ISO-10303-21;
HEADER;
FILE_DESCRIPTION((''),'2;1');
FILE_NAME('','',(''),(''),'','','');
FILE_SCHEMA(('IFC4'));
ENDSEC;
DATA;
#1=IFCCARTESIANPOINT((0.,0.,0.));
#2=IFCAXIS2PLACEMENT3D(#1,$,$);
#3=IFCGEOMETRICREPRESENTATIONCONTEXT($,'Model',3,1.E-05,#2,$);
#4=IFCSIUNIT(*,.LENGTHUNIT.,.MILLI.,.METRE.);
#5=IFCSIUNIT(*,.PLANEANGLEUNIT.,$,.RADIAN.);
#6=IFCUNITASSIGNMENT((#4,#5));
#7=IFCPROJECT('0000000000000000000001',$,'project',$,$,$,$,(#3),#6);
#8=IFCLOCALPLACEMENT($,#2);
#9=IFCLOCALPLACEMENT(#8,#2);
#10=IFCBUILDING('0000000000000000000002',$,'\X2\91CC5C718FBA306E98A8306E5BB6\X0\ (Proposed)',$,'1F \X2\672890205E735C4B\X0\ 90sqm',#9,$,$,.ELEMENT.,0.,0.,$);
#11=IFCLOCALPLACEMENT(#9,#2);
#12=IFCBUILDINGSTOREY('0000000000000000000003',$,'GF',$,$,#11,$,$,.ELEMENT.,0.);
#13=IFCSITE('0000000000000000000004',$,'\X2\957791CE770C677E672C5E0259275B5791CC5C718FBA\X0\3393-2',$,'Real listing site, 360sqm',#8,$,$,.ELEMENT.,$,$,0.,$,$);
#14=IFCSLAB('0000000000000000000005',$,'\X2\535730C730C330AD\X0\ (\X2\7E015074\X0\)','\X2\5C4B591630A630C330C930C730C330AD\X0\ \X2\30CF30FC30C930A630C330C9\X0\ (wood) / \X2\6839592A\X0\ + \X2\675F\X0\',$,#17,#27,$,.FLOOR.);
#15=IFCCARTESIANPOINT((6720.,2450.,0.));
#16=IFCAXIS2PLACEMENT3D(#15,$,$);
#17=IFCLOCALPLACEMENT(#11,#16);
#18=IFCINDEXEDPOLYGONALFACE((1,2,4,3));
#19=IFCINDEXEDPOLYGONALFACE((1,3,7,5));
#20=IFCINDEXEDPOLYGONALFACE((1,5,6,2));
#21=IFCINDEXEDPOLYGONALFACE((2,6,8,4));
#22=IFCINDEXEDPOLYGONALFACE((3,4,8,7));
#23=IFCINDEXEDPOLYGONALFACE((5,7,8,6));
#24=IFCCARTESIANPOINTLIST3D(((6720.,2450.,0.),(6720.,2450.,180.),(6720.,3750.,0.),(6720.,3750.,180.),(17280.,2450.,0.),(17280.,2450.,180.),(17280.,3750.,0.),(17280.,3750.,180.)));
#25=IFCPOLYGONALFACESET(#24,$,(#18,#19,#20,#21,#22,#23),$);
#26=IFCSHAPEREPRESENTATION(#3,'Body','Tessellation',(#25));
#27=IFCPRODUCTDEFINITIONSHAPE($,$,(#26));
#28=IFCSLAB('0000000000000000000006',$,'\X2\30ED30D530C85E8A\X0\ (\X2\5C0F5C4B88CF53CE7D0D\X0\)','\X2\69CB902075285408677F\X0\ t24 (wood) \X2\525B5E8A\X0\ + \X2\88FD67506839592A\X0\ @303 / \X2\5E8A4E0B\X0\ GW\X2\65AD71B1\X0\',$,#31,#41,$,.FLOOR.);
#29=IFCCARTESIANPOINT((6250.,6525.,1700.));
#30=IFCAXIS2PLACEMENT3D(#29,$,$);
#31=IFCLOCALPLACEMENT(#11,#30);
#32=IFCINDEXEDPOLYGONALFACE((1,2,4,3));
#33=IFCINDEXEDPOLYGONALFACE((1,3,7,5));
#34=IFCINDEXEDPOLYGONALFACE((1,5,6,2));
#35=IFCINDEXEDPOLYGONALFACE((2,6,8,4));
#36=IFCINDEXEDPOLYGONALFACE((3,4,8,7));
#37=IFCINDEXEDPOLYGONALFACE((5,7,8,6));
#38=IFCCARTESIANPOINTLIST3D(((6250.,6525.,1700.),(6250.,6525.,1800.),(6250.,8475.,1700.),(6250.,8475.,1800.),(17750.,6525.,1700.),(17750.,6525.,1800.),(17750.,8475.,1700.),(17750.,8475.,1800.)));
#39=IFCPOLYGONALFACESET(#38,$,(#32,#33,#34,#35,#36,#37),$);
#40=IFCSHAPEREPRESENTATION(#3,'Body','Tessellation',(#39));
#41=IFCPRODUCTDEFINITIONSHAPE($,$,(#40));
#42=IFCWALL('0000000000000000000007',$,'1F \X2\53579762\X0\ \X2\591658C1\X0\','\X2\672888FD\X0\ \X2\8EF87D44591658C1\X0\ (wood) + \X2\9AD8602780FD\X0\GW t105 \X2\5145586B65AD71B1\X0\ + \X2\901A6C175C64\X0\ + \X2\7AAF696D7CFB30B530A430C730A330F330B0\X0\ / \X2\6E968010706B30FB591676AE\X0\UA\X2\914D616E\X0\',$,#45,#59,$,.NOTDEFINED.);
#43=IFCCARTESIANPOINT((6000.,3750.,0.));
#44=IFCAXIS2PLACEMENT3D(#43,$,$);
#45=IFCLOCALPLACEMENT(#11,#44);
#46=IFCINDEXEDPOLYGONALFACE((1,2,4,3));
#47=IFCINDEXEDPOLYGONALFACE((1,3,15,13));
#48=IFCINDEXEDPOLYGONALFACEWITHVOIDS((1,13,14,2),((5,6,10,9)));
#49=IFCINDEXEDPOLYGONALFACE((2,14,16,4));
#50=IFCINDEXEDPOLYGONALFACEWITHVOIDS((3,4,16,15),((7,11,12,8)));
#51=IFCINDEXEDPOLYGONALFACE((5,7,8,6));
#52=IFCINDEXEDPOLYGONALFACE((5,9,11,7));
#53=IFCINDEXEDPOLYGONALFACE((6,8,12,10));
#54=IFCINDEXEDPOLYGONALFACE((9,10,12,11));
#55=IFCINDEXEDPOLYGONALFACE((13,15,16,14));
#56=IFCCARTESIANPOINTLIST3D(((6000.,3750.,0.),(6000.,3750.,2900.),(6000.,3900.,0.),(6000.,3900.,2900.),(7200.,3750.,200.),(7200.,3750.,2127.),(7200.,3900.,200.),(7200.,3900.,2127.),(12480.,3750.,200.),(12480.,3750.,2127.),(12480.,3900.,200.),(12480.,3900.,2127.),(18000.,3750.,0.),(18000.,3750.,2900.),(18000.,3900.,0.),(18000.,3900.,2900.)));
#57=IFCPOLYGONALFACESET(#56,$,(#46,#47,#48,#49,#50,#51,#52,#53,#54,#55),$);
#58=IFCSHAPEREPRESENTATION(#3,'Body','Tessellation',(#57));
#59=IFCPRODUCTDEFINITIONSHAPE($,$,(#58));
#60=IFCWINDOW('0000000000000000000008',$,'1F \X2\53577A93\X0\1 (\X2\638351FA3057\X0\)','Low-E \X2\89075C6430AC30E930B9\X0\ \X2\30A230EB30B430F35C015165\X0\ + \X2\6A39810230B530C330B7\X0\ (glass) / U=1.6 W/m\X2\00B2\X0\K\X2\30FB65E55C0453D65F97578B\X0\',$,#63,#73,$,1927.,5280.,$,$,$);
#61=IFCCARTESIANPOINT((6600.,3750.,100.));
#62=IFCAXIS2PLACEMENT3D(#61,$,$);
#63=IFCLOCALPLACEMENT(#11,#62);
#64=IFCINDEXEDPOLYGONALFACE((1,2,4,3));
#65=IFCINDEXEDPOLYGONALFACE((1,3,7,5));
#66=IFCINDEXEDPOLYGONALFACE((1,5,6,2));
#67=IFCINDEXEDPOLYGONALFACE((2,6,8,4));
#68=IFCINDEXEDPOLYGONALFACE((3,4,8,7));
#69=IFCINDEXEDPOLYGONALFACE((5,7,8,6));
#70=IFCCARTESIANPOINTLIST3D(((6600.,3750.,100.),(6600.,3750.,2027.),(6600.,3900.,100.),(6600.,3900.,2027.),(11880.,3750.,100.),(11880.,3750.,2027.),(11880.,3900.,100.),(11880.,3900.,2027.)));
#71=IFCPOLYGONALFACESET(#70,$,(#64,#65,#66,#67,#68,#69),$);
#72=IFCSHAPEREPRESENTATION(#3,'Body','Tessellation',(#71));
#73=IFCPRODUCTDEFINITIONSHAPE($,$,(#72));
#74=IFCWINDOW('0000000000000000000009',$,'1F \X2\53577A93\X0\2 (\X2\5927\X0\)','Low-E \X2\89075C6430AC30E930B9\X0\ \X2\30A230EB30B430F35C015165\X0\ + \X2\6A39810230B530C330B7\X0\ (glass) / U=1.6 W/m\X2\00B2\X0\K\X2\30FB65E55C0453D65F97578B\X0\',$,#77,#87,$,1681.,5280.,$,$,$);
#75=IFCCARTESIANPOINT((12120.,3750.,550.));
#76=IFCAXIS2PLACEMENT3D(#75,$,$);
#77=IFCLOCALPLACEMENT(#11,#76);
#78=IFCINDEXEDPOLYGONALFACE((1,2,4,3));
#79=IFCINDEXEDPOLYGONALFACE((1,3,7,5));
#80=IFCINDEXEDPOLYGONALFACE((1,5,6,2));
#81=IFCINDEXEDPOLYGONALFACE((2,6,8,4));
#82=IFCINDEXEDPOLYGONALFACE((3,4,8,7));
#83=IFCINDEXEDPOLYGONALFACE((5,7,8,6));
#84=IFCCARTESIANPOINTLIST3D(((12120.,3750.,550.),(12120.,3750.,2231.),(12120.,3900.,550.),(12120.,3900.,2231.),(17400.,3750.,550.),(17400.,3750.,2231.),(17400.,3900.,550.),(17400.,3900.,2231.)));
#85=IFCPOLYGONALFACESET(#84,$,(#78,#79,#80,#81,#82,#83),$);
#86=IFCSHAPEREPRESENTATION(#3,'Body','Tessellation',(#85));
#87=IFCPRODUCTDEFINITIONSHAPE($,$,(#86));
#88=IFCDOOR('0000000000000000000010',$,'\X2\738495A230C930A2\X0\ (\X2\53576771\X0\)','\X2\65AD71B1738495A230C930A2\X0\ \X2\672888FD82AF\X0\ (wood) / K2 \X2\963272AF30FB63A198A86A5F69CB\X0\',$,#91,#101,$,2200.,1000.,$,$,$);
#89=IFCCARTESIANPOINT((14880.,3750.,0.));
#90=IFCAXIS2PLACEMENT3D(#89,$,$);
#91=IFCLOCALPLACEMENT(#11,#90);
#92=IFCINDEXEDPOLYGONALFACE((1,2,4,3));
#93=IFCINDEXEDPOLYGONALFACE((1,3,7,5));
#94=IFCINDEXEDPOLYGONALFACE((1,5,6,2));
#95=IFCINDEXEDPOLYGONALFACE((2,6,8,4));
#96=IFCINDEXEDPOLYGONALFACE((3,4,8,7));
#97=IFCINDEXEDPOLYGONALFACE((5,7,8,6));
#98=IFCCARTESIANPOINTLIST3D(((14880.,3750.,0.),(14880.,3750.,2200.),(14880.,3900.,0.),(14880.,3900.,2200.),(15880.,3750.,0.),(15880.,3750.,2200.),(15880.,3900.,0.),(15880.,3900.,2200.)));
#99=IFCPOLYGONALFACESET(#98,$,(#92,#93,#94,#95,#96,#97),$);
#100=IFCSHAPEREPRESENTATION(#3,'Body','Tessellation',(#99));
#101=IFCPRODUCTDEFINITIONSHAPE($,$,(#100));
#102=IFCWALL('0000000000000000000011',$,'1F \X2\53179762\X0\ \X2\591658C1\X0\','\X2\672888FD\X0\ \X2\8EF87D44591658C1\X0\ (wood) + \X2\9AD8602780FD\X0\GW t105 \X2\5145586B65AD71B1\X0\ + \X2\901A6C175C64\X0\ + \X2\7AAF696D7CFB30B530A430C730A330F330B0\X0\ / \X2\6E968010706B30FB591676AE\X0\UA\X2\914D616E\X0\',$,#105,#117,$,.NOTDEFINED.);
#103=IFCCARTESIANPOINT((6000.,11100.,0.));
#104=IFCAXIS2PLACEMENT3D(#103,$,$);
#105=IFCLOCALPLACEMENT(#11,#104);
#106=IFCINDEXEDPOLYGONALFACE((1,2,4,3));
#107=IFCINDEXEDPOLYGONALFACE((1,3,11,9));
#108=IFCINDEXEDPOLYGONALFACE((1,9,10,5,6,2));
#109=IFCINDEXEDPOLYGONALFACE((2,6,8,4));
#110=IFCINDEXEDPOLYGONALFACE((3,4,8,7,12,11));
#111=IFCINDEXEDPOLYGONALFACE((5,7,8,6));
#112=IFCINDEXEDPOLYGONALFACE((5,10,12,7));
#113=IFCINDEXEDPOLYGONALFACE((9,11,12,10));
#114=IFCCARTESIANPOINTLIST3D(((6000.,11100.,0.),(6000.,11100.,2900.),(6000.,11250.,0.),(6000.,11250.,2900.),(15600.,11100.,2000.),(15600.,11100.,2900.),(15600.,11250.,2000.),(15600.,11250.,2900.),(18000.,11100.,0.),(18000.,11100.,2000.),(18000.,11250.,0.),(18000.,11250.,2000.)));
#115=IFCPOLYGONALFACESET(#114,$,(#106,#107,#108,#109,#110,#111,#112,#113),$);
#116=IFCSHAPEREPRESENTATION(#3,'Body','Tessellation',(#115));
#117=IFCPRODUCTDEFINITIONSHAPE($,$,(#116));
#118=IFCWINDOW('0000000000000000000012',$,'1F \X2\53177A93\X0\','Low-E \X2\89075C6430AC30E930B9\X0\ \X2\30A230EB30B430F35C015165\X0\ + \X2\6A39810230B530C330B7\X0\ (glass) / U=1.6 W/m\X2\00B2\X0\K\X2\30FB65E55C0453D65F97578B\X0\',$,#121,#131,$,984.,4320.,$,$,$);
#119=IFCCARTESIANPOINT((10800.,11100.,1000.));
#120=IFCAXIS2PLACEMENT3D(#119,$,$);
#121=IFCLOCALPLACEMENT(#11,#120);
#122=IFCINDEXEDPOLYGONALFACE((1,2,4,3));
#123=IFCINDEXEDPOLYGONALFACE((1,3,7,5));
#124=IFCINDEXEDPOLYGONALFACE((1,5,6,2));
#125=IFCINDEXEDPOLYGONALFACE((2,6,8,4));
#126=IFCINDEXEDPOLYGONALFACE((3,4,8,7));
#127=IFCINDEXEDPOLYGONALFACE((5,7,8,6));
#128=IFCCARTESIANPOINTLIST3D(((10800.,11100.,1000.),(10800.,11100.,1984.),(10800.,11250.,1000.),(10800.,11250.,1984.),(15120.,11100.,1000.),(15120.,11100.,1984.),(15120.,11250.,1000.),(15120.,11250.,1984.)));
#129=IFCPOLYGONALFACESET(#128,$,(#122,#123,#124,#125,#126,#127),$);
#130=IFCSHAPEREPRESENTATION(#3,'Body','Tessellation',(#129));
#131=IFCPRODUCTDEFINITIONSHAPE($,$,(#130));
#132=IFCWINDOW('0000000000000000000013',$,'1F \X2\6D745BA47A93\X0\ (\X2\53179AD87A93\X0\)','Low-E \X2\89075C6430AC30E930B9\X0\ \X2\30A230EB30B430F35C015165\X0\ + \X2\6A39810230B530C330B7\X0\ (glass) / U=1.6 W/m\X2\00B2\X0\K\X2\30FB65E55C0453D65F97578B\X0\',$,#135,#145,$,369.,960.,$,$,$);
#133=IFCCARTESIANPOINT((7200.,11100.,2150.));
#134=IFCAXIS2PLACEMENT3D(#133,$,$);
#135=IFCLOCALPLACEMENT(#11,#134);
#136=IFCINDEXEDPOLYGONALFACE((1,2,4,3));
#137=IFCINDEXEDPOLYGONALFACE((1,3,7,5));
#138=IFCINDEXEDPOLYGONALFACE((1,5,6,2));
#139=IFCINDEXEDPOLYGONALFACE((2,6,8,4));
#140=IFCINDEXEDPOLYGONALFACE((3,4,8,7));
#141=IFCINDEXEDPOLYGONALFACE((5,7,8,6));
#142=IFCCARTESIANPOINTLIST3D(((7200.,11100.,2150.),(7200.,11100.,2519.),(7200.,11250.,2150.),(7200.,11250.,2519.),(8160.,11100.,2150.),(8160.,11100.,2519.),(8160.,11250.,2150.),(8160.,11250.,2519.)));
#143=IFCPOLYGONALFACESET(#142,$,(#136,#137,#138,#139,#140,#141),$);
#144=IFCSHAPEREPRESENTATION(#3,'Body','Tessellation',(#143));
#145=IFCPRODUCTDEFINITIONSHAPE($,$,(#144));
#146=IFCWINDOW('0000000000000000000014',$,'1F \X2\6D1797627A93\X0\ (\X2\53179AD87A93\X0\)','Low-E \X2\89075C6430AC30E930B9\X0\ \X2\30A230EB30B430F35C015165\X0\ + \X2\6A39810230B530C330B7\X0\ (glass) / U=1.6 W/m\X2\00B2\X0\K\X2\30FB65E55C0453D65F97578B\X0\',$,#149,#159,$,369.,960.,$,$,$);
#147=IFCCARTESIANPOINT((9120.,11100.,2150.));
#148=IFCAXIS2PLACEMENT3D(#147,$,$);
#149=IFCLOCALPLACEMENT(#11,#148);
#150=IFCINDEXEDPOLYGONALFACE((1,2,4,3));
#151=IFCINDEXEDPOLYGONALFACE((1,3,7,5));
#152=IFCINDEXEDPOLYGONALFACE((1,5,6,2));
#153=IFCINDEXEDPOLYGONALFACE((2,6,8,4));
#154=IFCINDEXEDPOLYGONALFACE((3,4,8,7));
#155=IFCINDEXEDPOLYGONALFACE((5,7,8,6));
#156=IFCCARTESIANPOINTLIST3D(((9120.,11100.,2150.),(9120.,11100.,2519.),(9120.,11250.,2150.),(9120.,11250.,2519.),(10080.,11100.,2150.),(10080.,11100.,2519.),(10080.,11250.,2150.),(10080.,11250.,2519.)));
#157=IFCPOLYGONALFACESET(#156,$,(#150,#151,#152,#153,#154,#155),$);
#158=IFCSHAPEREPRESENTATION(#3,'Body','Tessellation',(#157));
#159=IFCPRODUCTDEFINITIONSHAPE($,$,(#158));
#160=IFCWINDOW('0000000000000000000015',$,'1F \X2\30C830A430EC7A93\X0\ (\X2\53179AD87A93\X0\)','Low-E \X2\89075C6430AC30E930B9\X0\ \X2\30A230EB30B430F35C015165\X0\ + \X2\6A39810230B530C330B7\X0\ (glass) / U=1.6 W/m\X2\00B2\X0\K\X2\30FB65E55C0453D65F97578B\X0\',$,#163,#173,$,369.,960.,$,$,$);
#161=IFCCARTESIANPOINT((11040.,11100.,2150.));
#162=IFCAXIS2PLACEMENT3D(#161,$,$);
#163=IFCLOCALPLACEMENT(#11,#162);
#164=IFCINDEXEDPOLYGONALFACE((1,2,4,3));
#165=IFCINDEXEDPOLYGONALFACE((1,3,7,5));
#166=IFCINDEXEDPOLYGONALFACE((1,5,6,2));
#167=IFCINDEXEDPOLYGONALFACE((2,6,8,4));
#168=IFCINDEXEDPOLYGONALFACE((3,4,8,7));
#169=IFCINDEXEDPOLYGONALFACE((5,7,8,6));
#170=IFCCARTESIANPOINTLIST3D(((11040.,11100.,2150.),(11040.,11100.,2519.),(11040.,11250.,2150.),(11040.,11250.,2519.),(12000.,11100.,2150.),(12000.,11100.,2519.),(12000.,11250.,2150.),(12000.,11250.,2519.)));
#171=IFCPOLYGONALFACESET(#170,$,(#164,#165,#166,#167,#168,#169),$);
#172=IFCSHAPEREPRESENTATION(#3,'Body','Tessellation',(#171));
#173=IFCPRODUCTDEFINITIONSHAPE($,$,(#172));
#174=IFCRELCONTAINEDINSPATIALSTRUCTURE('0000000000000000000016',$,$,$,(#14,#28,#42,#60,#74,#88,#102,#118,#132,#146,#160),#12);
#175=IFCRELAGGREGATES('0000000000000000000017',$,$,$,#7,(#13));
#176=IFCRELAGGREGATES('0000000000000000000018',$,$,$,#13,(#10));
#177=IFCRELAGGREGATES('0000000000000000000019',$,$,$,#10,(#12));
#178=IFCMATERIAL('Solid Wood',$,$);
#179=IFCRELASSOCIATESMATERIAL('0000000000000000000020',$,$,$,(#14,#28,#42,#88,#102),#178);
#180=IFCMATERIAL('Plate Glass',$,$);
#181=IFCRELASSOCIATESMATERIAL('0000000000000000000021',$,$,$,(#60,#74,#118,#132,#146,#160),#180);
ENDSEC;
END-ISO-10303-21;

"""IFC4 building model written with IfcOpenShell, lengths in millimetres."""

from ifc_helpers import new_model, si_unit, frame, frame_2d, origin, place, context, project, spatial, rectangle, extrude, material, element, fill, save


model = new_model("IFC4")

# Units and contexts
model_context = context("Model", 3, precision=1e-05, world=origin())
ifc_project = project(units=[si_unit("LENGTHUNIT", "METRE", prefix="MILLI"), si_unit("PLANEANGLEUNIT", "RADIAN")], contexts=[model_context])

# Site, building, storey
site_placement = place(None, origin())
site = spatial("IfcSite", under=ifc_project, at=site_placement, Name="長野県松本市大字里山辺3393-2", ObjectType="Real listing site, 360sqm", CompositionType="ELEMENT", RefElevation=0.0)
building_placement = place(site_placement, origin())
building = spatial("IfcBuilding", under=site, at=building_placement, Name="里山辺の風の家 (Proposed)", ObjectType="1F 木造平屋 90sqm", CompositionType="ELEMENT", ElevationOfRefHeight=0.0, ElevationOfTerrain=0.0)
storey_placement = place(building_placement, origin())
storey = spatial("IfcBuildingStorey", under=building, at=storey_placement, Name="GF", CompositionType="ELEMENT", Elevation=0.0)

# Slabs
ifc_material_1 = material(Name="Solid Wood")
slab_1_placement = place(storey_placement, frame((6720.0, 2450.0, 0.0)))
element("IfcSlab", 1, at=slab_1_placement, inside=storey, material=ifc_material_1, Name="南デッキ (縁側)", Description="屋外ウッドデッキ ハードウッド (wood) / 根太 + 束", PredefinedType="FLOOR", context=model_context, shape_type="SweptSolid", body=[
    extrude(rectangle(XDim=10560.0, YDim=1300.0, at=frame_2d((5280.0, 650.0))), frame((6720.0, 2450.0, 0.0)), (0.0, 0.0, 1.0), 180.0),
])
slab_2_placement = place(storey_placement, frame((6250.0, 6525.0, 1700.0)))
element("IfcSlab", 2, at=slab_2_placement, inside=storey, material=ifc_material_1, Name="ロフト床 (小屋裏収納)", Description="構造用合板 t24 (wood) 剛床 + 製材根太 @303 / 床下 GW断熱", PredefinedType="FLOOR", context=model_context, shape_type="SweptSolid", body=[
    extrude(rectangle(XDim=11500.0, YDim=1950.0, at=frame_2d((5750.0, 975.0))), frame((6250.0, 6525.0, 1700.0)), (0.0, 0.0, 1.0), 100.0),
])

# Wall, openings, windows, door
wall_1_placement = place(storey_placement, frame((6000.0, 3750.0, 0.0)))
wall_1 = element("IfcWall", 3, at=wall_1_placement, inside=storey, material=ifc_material_1, Name="1F 南面 外壁", Description="木製 軸組外壁 (wood) + 高性能GW t105 充填断熱 + 通気層 + 窯業系サイディング / 準耐火・外皮UA配慮", PredefinedType="NOTDEFINED", context=model_context, shape_type="SweptSolid", body=[
    extrude(rectangle(XDim=12000.0, YDim=150.0, at=frame_2d((6000.0, 75.0))), frame((6000.0, 3750.0, 0.0)), (0.0, 0.0, 1.0), 2900.0),
])
opening_1_placement = place(storey_placement, frame((6600.0, 3750.0, 100.0)))
opening_1 = element("IfcOpeningElement", 4, at=opening_1_placement, cuts=wall_1, PredefinedType="NOTDEFINED", context=model_context, shape_type="SweptSolid", body=[
    extrude(rectangle(XDim=5280.0, YDim=150.0, at=frame_2d((2640.0, 75.0))), frame((6600.0, 3750.0, 100.0)), (0.0, 0.0, 1.0), 1927.0),
])
opening_2_placement = place(storey_placement, frame((12120.0, 3750.0, 550.0)))
opening_2 = element("IfcOpeningElement", 5, at=opening_2_placement, cuts=wall_1, PredefinedType="NOTDEFINED", context=model_context, shape_type="SweptSolid", body=[
    extrude(rectangle(XDim=5280.0, YDim=150.0, at=frame_2d((2640.0, 75.0))), frame((12120.0, 3750.0, 550.0)), (0.0, 0.0, 1.0), 1681.0),
])
opening_3_placement = place(storey_placement, frame((14880.0, 3750.0, 0.0)))
opening_3 = element("IfcOpeningElement", 6, at=opening_3_placement, cuts=wall_1, PredefinedType="NOTDEFINED", context=model_context, shape_type="SweptSolid", body=[
    extrude(rectangle(XDim=1000.0, YDim=150.0, at=frame_2d((500.0, 75.0))), frame((14880.0, 3750.0, 0.0)), (0.0, 0.0, 1.0), 2200.0),
])
ifc_material_2 = material(Name="Plate Glass")
window_1_placement = place(storey_placement, frame((6600.0, 3750.0, 100.0)))
window_1 = element("IfcWindow", 7, at=window_1_placement, inside=storey, material=ifc_material_2, Name="1F 南窓1 (掃出し)", Description="Low-E 複層ガラス アルゴン封入 + 樹脂サッシ (glass) / U=1.6 W/m²K・日射取得型", OverallHeight=1927.0, OverallWidth=5280.0, context=model_context, shape_type="SweptSolid", body=[
    extrude(rectangle(XDim=5280.0, YDim=150.0, at=frame_2d((2640.0, 75.0))), frame((6600.0, 3750.0, 100.0)), (0.0, 0.0, 1.0), 1927.0),
])
fill(opening_1, window_1)
window_2_placement = place(storey_placement, frame((12120.0, 3750.0, 550.0)))
window_2 = element("IfcWindow", 8, at=window_2_placement, inside=storey, material=ifc_material_2, Name="1F 南窓2 (大)", Description="Low-E 複層ガラス アルゴン封入 + 樹脂サッシ (glass) / U=1.6 W/m²K・日射取得型", OverallHeight=1681.0, OverallWidth=5280.0, context=model_context, shape_type="SweptSolid", body=[
    extrude(rectangle(XDim=5280.0, YDim=150.0, at=frame_2d((2640.0, 75.0))), frame((12120.0, 3750.0, 550.0)), (0.0, 0.0, 1.0), 1681.0),
])
fill(opening_2, window_2)
door_1_placement = place(storey_placement, frame((14880.0, 3750.0, 0.0)))
door_1 = element("IfcDoor", 9, at=door_1_placement, inside=storey, material=ifc_material_1, Name="玄関ドア (南東)", Description="断熱玄関ドア 木製芯 (wood) / K2 防犯・採風機構", OverallHeight=2200.0, OverallWidth=1000.0, context=model_context, shape_type="SweptSolid", body=[
    extrude(rectangle(XDim=1000.0, YDim=150.0, at=frame_2d((500.0, 75.0))), frame((14880.0, 3750.0, 0.0)), (0.0, 0.0, 1.0), 2200.0),
])
fill(opening_3, door_1)

# Wall, openings, windows
wall_2_placement = place(storey_placement, frame((6000.0, 11100.0, 0.0)))
wall_2 = element("IfcWall", 10, at=wall_2_placement, inside=storey, material=ifc_material_1, Name="1F 北面 外壁", Description="木製 軸組外壁 (wood) + 高性能GW t105 充填断熱 + 通気層 + 窯業系サイディング / 準耐火・外皮UA配慮", PredefinedType="NOTDEFINED", context=model_context, shape_type="SweptSolid", body=[
    extrude(rectangle(XDim=12000.0, YDim=150.0, at=frame_2d((6000.0, 75.0))), frame((6000.0, 11100.0, 0.0)), (0.0, 0.0, 1.0), 2900.0),
])
opening_4_placement = place(storey_placement, frame((10800.0, 11100.0, 1000.0)))
opening_4 = element("IfcOpeningElement", 11, at=opening_4_placement, cuts=wall_2, PredefinedType="NOTDEFINED", context=model_context, shape_type="SweptSolid", body=[
    extrude(rectangle(XDim=4320.0, YDim=150.0, at=frame_2d((2160.0, 75.0))), frame((10800.0, 11100.0, 1000.0)), (0.0, 0.0, 1.0), 984.0),
])
opening_5_placement = place(storey_placement, frame((7200.0, 11100.0, 2150.0)))
opening_5 = element("IfcOpeningElement", 12, at=opening_5_placement, cuts=wall_2, PredefinedType="NOTDEFINED", context=model_context, shape_type="SweptSolid", body=[
    extrude(rectangle(XDim=960.0, YDim=150.0, at=frame_2d((480.0, 75.0))), frame((7200.0, 11100.0, 2150.0)), (0.0, 0.0, 1.0), 369.0),
])
opening_6_placement = place(storey_placement, frame((9120.0, 11100.0, 2150.0)))
opening_6 = element("IfcOpeningElement", 13, at=opening_6_placement, cuts=wall_2, PredefinedType="NOTDEFINED", context=model_context, shape_type="SweptSolid", body=[
    extrude(rectangle(XDim=960.0, YDim=150.0, at=frame_2d((480.0, 75.0))), frame((9120.0, 11100.0, 2150.0)), (0.0, 0.0, 1.0), 369.0),
])
opening_7_placement = place(storey_placement, frame((11040.0, 11100.0, 2150.0)))
opening_7 = element("IfcOpeningElement", 14, at=opening_7_placement, cuts=wall_2, PredefinedType="NOTDEFINED", context=model_context, shape_type="SweptSolid", body=[
    extrude(rectangle(XDim=960.0, YDim=150.0, at=frame_2d((480.0, 75.0))), frame((11040.0, 11100.0, 2150.0)), (0.0, 0.0, 1.0), 369.0),
])
window_3_placement = place(storey_placement, frame((10800.0, 11100.0, 1000.0)))
window_3 = element("IfcWindow", 15, at=window_3_placement, inside=storey, material=ifc_material_2, Name="1F 北窓", Description="Low-E 複層ガラス アルゴン封入 + 樹脂サッシ (glass) / U=1.6 W/m²K・日射取得型", OverallHeight=984.0, OverallWidth=4320.0, context=model_context, shape_type="SweptSolid", body=[
    extrude(rectangle(XDim=4320.0, YDim=150.0, at=frame_2d((2160.0, 75.0))), frame((10800.0, 11100.0, 1000.0)), (0.0, 0.0, 1.0), 984.0),
])
fill(opening_4, window_3)
window_4_placement = place(storey_placement, frame((7200.0, 11100.0, 2150.0)))
window_4 = element("IfcWindow", 16, at=window_4_placement, inside=storey, material=ifc_material_2, Name="1F 浴室窓 (北高窓)", Description="Low-E 複層ガラス アルゴン封入 + 樹脂サッシ (glass) / U=1.6 W/m²K・日射取得型", OverallHeight=369.0, OverallWidth=960.0, context=model_context, shape_type="SweptSolid", body=[
    extrude(rectangle(XDim=960.0, YDim=150.0, at=frame_2d((480.0, 75.0))), frame((7200.0, 11100.0, 2150.0)), (0.0, 0.0, 1.0), 369.0),
])
fill(opening_5, window_4)
window_5_placement = place(storey_placement, frame((9120.0, 11100.0, 2150.0)))
window_5 = element("IfcWindow", 17, at=window_5_placement, inside=storey, material=ifc_material_2, Name="1F 洗面窓 (北高窓)", Description="Low-E 複層ガラス アルゴン封入 + 樹脂サッシ (glass) / U=1.6 W/m²K・日射取得型", OverallHeight=369.0, OverallWidth=960.0, context=model_context, shape_type="SweptSolid", body=[
    extrude(rectangle(XDim=960.0, YDim=150.0, at=frame_2d((480.0, 75.0))), frame((9120.0, 11100.0, 2150.0)), (0.0, 0.0, 1.0), 369.0),
])
fill(opening_6, window_5)
window_6_placement = place(storey_placement, frame((11040.0, 11100.0, 2150.0)))
window_6 = element("IfcWindow", 18, at=window_6_placement, inside=storey, material=ifc_material_2, Name="1F トイレ窓 (北高窓)", Description="Low-E 複層ガラス アルゴン封入 + 樹脂サッシ (glass) / U=1.6 W/m²K・日射取得型", OverallHeight=369.0, OverallWidth=960.0, context=model_context, shape_type="SweptSolid", body=[
    extrude(rectangle(XDim=960.0, YDim=150.0, at=frame_2d((480.0, 75.0))), frame((11040.0, 11100.0, 2150.0)), (0.0, 0.0, 1.0), 369.0),
])
fill(opening_7, window_6)

save(model, "model.ifc")
